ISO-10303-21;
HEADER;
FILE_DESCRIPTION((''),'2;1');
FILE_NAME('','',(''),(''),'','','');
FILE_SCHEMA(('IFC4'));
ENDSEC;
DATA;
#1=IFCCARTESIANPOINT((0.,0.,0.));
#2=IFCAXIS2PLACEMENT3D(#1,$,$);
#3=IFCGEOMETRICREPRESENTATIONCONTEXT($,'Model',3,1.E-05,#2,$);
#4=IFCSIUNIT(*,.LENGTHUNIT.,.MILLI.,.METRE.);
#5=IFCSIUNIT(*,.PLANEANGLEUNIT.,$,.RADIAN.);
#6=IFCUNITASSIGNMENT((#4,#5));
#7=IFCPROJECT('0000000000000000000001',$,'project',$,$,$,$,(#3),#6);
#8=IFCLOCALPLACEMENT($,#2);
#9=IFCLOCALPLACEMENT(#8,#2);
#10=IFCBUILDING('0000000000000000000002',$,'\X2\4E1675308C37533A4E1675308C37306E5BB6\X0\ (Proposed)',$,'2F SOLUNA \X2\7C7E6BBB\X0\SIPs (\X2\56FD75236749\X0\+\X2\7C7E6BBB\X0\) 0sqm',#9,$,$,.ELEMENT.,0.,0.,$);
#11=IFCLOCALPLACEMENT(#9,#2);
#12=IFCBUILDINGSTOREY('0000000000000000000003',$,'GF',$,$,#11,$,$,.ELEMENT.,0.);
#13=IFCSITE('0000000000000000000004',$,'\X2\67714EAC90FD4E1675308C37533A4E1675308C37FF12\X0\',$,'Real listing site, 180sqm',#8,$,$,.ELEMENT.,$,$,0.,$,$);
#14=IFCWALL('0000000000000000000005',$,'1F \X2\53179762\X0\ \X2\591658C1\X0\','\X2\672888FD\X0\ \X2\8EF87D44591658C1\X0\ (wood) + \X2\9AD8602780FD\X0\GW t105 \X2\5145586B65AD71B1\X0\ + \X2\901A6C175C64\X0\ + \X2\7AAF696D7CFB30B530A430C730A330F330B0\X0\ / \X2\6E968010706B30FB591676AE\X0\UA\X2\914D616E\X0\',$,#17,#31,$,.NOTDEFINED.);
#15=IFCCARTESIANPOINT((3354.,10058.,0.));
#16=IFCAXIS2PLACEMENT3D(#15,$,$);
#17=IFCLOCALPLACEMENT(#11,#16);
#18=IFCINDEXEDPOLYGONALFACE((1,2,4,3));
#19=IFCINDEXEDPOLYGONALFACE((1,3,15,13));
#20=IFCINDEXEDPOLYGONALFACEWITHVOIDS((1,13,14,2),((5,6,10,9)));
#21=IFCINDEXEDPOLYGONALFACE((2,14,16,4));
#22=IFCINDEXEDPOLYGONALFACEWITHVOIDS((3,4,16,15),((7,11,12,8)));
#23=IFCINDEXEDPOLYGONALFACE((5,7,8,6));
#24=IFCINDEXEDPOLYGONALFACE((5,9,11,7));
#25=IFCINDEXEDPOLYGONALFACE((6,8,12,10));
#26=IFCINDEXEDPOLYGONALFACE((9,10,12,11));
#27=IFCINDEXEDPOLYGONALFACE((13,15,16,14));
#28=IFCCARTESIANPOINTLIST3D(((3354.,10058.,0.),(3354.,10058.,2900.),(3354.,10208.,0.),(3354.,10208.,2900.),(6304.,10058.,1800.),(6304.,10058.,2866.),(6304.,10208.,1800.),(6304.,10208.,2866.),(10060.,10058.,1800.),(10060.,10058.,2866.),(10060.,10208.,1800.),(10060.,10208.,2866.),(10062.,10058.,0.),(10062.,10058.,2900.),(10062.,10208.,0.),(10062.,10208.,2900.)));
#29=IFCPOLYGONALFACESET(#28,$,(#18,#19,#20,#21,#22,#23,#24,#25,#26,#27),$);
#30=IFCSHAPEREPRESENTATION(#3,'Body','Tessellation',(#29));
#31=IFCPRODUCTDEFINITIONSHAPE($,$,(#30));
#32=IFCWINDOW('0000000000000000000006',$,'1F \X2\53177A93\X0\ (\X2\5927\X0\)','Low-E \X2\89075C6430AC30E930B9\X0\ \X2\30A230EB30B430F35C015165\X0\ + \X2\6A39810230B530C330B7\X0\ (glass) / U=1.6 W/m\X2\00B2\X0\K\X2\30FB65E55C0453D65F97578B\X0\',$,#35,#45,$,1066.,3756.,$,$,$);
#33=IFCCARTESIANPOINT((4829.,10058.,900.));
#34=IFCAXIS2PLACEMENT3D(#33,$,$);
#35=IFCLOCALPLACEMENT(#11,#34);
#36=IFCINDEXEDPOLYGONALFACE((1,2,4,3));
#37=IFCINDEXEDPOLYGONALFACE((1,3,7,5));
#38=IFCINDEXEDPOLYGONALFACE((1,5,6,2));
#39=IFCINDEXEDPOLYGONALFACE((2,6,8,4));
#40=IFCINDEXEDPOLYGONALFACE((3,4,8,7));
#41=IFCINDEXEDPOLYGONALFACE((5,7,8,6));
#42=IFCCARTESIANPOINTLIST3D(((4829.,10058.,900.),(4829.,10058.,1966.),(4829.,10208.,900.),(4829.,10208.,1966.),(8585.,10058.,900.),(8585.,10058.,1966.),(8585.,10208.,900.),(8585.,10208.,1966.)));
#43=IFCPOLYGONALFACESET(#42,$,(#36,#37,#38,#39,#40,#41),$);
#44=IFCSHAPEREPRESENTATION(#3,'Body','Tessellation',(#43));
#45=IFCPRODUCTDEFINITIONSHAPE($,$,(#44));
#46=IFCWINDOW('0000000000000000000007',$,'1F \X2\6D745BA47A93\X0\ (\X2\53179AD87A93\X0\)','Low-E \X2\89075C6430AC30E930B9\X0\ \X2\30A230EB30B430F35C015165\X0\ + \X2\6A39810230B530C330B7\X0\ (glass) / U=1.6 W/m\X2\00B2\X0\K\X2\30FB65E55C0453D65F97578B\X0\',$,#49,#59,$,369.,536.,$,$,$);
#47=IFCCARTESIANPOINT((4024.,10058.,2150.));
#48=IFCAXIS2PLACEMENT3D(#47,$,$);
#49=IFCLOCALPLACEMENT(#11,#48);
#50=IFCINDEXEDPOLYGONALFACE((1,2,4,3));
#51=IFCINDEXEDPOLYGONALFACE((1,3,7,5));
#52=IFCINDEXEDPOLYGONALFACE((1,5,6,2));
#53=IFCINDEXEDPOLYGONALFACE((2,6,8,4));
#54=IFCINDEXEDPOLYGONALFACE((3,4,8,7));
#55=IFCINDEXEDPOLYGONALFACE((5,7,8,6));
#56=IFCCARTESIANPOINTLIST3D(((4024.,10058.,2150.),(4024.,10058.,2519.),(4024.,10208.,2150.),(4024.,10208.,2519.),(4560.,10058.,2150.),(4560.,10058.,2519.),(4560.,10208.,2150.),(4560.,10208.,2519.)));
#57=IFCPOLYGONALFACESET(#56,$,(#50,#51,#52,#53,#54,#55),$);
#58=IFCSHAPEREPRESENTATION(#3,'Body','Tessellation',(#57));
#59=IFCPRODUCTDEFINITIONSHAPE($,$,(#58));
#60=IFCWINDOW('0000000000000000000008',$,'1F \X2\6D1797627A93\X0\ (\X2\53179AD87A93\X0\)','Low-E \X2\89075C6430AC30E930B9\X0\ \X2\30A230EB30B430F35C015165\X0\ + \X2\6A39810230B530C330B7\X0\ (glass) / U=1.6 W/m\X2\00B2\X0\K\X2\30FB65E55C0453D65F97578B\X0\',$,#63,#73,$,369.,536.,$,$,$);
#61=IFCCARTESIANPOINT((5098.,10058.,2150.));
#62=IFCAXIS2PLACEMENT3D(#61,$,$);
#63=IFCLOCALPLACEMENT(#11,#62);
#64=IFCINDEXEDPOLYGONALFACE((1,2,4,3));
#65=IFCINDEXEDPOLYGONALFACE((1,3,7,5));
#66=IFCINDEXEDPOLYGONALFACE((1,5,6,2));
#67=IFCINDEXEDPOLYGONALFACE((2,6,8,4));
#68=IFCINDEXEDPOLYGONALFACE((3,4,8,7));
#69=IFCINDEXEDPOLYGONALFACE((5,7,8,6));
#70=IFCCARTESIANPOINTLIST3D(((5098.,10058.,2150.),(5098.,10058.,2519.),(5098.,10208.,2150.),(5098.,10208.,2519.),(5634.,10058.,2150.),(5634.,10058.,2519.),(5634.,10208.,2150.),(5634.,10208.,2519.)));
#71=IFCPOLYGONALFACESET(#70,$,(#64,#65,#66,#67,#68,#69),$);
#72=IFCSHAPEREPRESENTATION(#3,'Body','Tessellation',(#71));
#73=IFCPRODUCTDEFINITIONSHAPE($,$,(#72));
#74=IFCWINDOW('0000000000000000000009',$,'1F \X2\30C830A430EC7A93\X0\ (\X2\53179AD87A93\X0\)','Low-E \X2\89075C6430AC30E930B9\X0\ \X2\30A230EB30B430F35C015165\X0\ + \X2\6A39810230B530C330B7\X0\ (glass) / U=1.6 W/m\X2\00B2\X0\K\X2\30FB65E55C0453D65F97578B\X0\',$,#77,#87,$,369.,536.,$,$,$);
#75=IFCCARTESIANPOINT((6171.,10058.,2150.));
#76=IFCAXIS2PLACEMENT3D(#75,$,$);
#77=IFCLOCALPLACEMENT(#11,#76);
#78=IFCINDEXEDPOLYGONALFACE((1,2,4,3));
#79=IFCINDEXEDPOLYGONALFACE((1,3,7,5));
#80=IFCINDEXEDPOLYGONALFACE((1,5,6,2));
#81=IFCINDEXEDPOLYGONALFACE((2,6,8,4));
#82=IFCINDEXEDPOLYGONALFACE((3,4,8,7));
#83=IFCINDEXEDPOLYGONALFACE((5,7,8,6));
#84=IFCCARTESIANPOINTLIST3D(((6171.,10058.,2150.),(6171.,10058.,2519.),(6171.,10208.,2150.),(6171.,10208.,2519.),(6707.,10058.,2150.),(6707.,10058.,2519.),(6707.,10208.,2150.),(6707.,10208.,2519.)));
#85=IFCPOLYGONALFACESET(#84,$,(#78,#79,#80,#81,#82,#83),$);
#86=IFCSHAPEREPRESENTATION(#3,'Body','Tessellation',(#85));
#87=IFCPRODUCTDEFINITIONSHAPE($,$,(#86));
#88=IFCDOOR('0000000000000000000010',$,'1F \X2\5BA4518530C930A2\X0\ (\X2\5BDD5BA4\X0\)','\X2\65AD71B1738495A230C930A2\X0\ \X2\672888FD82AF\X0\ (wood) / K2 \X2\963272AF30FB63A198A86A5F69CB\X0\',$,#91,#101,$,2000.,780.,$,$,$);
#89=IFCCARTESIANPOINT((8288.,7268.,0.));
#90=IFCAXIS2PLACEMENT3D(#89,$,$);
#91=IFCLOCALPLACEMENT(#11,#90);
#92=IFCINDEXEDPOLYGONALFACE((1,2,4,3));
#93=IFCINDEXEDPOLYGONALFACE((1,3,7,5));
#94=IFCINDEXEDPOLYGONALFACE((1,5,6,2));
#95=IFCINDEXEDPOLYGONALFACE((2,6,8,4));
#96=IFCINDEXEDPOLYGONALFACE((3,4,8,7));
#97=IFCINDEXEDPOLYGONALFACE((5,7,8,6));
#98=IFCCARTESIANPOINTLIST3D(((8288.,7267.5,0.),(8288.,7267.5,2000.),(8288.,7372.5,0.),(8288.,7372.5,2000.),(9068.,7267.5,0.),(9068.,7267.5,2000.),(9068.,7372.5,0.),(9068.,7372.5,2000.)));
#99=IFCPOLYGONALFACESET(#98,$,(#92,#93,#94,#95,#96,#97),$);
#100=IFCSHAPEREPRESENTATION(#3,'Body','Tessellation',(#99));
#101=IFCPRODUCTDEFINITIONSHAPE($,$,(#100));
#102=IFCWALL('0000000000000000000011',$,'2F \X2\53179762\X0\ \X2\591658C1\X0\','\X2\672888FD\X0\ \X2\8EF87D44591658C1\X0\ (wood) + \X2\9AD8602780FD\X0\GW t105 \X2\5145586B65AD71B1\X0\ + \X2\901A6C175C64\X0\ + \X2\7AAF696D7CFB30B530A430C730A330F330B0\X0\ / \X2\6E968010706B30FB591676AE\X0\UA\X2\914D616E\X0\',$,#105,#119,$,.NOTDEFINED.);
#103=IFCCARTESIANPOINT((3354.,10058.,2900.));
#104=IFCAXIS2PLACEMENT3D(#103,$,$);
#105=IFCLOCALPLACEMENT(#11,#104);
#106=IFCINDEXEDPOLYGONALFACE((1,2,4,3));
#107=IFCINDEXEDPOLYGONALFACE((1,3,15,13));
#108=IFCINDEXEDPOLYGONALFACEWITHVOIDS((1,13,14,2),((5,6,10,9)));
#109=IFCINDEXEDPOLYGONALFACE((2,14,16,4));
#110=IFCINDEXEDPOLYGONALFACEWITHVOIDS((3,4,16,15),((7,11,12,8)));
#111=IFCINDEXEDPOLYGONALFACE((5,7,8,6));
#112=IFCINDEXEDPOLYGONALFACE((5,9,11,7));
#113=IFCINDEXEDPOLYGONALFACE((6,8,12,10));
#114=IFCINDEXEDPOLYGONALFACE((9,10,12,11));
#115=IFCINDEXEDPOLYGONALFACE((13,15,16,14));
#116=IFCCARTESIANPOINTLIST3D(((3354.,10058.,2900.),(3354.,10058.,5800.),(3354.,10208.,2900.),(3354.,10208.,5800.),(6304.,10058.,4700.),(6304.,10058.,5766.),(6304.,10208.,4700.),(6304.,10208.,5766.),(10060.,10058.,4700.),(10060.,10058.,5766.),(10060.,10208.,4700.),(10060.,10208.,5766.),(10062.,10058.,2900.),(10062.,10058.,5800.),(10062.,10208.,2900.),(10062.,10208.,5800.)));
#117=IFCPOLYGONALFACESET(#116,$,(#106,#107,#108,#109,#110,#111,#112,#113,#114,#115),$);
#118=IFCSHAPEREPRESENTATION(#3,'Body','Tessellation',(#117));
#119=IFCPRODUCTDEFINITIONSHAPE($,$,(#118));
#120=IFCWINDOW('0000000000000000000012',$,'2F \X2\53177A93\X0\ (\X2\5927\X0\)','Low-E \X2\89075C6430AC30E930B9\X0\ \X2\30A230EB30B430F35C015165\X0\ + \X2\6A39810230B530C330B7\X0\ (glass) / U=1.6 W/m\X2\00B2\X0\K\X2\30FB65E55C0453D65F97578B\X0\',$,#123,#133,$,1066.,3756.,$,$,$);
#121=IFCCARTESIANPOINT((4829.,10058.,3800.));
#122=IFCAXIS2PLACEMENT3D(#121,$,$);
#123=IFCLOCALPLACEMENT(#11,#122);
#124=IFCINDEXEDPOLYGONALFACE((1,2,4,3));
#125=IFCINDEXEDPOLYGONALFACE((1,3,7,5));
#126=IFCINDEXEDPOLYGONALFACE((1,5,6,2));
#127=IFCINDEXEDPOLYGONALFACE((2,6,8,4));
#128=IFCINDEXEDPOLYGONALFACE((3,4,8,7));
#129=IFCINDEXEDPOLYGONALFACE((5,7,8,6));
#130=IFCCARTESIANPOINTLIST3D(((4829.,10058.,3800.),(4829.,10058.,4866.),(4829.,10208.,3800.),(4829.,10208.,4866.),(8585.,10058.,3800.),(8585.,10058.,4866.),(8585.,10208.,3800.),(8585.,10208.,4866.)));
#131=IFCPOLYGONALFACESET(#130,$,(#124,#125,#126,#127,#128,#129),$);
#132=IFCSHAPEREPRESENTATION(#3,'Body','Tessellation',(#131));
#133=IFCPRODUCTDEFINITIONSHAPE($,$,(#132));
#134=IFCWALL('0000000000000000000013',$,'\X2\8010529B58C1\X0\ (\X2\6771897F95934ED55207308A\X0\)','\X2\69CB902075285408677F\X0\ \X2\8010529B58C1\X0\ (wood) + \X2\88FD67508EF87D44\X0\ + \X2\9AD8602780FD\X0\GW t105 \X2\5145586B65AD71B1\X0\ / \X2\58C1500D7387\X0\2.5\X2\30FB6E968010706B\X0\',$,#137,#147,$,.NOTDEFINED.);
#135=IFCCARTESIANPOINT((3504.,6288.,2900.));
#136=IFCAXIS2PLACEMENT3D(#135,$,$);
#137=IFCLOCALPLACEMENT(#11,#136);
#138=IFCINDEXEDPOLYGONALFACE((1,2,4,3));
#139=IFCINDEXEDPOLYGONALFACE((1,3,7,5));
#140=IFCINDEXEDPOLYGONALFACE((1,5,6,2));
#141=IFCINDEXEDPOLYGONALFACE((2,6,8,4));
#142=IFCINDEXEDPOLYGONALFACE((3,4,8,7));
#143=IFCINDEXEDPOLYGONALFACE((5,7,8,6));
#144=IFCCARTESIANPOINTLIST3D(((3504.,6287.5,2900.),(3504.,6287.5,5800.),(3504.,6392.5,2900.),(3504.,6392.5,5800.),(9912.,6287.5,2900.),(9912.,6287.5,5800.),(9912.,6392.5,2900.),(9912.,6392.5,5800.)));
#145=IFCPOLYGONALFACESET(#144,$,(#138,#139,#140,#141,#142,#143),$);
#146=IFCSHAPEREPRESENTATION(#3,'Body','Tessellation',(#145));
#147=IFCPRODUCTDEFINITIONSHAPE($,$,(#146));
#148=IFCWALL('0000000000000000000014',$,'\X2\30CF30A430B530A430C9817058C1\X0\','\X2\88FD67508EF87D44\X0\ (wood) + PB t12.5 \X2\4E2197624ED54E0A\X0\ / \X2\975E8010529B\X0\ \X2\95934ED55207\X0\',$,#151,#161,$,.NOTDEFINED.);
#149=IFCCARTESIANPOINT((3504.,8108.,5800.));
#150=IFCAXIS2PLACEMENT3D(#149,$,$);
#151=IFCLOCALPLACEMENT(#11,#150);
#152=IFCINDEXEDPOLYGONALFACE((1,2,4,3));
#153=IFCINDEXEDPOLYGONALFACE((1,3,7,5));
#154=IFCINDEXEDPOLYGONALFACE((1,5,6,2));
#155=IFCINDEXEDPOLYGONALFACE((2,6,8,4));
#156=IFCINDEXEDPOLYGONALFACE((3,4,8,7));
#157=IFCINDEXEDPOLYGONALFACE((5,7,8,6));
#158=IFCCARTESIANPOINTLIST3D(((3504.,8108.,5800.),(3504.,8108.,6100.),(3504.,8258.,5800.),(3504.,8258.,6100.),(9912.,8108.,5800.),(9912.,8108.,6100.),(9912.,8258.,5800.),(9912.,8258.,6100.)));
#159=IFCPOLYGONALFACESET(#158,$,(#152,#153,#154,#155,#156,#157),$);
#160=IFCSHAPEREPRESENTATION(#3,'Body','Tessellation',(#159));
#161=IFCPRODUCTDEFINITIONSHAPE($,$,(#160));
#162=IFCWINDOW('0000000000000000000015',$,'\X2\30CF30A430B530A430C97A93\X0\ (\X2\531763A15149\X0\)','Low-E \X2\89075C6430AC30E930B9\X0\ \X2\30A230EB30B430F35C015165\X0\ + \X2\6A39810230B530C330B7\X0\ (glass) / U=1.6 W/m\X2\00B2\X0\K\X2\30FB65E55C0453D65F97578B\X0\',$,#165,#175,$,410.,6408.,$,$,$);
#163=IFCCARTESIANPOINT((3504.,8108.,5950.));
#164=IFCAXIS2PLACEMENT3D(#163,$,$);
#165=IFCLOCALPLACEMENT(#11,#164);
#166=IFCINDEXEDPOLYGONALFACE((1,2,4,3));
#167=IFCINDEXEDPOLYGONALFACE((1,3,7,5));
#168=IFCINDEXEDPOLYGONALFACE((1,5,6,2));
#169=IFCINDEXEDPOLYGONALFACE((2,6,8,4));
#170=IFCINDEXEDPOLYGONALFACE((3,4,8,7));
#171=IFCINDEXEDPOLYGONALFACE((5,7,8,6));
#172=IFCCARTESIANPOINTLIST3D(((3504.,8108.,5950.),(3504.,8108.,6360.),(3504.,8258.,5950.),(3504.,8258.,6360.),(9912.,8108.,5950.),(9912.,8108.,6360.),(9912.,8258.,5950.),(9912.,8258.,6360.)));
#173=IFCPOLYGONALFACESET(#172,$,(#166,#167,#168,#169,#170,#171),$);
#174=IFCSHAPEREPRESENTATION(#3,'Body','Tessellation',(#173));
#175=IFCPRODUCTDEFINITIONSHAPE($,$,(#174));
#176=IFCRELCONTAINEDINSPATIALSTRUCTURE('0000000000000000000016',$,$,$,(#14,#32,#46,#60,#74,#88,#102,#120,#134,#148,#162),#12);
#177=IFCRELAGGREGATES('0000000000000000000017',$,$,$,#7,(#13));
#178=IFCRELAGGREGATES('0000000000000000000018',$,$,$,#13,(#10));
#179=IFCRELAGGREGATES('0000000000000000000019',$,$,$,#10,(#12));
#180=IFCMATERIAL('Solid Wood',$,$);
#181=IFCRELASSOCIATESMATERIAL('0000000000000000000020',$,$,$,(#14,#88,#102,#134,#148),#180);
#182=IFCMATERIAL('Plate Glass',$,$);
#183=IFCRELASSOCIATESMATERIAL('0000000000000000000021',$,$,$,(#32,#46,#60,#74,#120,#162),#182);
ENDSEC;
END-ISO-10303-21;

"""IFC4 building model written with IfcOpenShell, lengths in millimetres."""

from ifc_helpers import new_model, si_unit, frame, frame_2d, origin, place, context, project, spatial, rectangle, extrude, material, element, fill, save


model = new_model("IFC4")

# Units and contexts
model_context = context("Model", 3, precision=1e-05, world=origin())
ifc_project = project(units=[si_unit("LENGTHUNIT", "METRE", prefix="MILLI"), si_unit("PLANEANGLEUNIT", "RADIAN")], contexts=[model_context])

# Site, building, storey
site_placement = place(None, origin())
site = spatial("IfcSite", under=ifc_project, at=site_placement, Name="東京都世田谷区世田谷２", ObjectType="Real listing site, 180sqm", CompositionType="ELEMENT", RefElevation=0.0)
building_placement = place(site_placement, origin())
building = spatial("IfcBuilding", under=site, at=building_placement, Name="世田谷区世田谷の家 (Proposed)", ObjectType="2F SOLUNA 籾殻SIPs (国産杉+籾殻) 0sqm", CompositionType="ELEMENT", ElevationOfRefHeight=0.0, ElevationOfTerrain=0.0)
storey_placement = place(building_placement, origin())
storey = spatial("IfcBuildingStorey", under=building, at=storey_placement, Name="GF", CompositionType="ELEMENT", Elevation=0.0)

# Wall, openings, windows
ifc_material_1 = material(Name="Solid Wood")
wall_1_placement = place(storey_placement, frame((3354.0, 10058.0, 0.0)))
wall_1 = element("IfcWall", 1, at=wall_1_placement, inside=storey, material=ifc_material_1, Name="1F 北面 外壁", Description="木製 軸組外壁 (wood) + 高性能GW t105 充填断熱 + 通気層 + 窯業系サイディング / 準耐火・外皮UA配慮", PredefinedType="NOTDEFINED", context=model_context, shape_type="SweptSolid", body=[
    extrude(rectangle(XDim=6708.0, YDim=150.0, at=frame_2d((3354.0, 75.0))), frame((3354.0, 10058.0, 0.0)), (0.0, 0.0, 1.0), 2900.0),
])
opening_1_placement = place(storey_placement, frame((4829.0, 10058.0, 900.0)))
opening_1 = element("IfcOpeningElement", 2, at=opening_1_placement, cuts=wall_1, PredefinedType="NOTDEFINED", context=model_context, shape_type="SweptSolid", body=[
    extrude(rectangle(XDim=3756.0, YDim=150.0, at=frame_2d((1878.0, 75.0))), frame((4829.0, 10058.0, 900.0)), (0.0, 0.0, 1.0), 1066.0),
])
opening_2_placement = place(storey_placement, frame((4024.0, 10058.0, 2150.0)))
opening_2 = element("IfcOpeningElement", 3, at=opening_2_placement, cuts=wall_1, PredefinedType="NOTDEFINED", context=model_context, shape_type="SweptSolid", body=[
    extrude(rectangle(XDim=536.0, YDim=150.0, at=frame_2d((268.0, 75.0))), frame((4024.0, 10058.0, 2150.0)), (0.0, 0.0, 1.0), 369.0),
])
opening_3_placement = place(storey_placement, frame((5098.0, 10058.0, 2150.0)))
opening_3 = element("IfcOpeningElement", 4, at=opening_3_placement, cuts=wall_1, PredefinedType="NOTDEFINED", context=model_context, shape_type="SweptSolid", body=[
    extrude(rectangle(XDim=536.0, YDim=150.0, at=frame_2d((268.0, 75.0))), frame((5098.0, 10058.0, 2150.0)), (0.0, 0.0, 1.0), 369.0),
])
opening_4_placement = place(storey_placement, frame((6171.0, 10058.0, 2150.0)))
opening_4 = element("IfcOpeningElement", 5, at=opening_4_placement, cuts=wall_1, PredefinedType="NOTDEFINED", context=model_context, shape_type="SweptSolid", body=[
    extrude(rectangle(XDim=536.0, YDim=150.0, at=frame_2d((268.0, 75.0))), frame((6171.0, 10058.0, 2150.0)), (0.0, 0.0, 1.0), 369.0),
])
ifc_material_2 = material(Name="Plate Glass")
window_1_placement = place(storey_placement, frame((4829.0, 10058.0, 900.0)))
window_1 = element("IfcWindow", 6, at=window_1_placement, inside=storey, material=ifc_material_2, Name="1F 北窓 (大)", Description="Low-E 複層ガラス アルゴン封入 + 樹脂サッシ (glass) / U=1.6 W/m²K・日射取得型", OverallHeight=1066.0, OverallWidth=3756.0, context=model_context, shape_type="SweptSolid", body=[
    extrude(rectangle(XDim=3756.0, YDim=150.0, at=frame_2d((1878.0, 75.0))), frame((4829.0, 10058.0, 900.0)), (0.0, 0.0, 1.0), 1066.0),
])
fill(opening_1, window_1)
window_2_placement = place(storey_placement, frame((4024.0, 10058.0, 2150.0)))
window_2 = element("IfcWindow", 7, at=window_2_placement, inside=storey, material=ifc_material_2, Name="1F 浴室窓 (北高窓)", Description="Low-E 複層ガラス アルゴン封入 + 樹脂サッシ (glass) / U=1.6 W/m²K・日射取得型", OverallHeight=369.0, OverallWidth=536.0, context=model_context, shape_type="SweptSolid", body=[
    extrude(rectangle(XDim=536.0, YDim=150.0, at=frame_2d((268.0, 75.0))), frame((4024.0, 10058.0, 2150.0)), (0.0, 0.0, 1.0), 369.0),
])
fill(opening_2, window_2)
window_3_placement = place(storey_placement, frame((5098.0, 10058.0, 2150.0)))
window_3 = element("IfcWindow", 8, at=window_3_placement, inside=storey, material=ifc_material_2, Name="1F 洗面窓 (北高窓)", Description="Low-E 複層ガラス アルゴン封入 + 樹脂サッシ (glass) / U=1.6 W/m²K・日射取得型", OverallHeight=369.0, OverallWidth=536.0, context=model_context, shape_type="SweptSolid", body=[
    extrude(rectangle(XDim=536.0, YDim=150.0, at=frame_2d((268.0, 75.0))), frame((5098.0, 10058.0, 2150.0)), (0.0, 0.0, 1.0), 369.0),
])
fill(opening_3, window_3)
window_4_placement = place(storey_placement, frame((6171.0, 10058.0, 2150.0)))
window_4 = element("IfcWindow", 9, at=window_4_placement, inside=storey, material=ifc_material_2, Name="1F トイレ窓 (北高窓)", Description="Low-E 複層ガラス アルゴン封入 + 樹脂サッシ (glass) / U=1.6 W/m²K・日射取得型", OverallHeight=369.0, OverallWidth=536.0, context=model_context, shape_type="SweptSolid", body=[
    extrude(rectangle(XDim=536.0, YDim=150.0, at=frame_2d((268.0, 75.0))), frame((6171.0, 10058.0, 2150.0)), (0.0, 0.0, 1.0), 369.0),
])
fill(opening_4, window_4)

# Door
door_1_placement = place(storey_placement, frame((8288.0, 7268.0, 0.0)))
element("IfcDoor", 10, at=door_1_placement, inside=storey, material=ifc_material_1, Name="1F 室内ドア (寝室)", Description="断熱玄関ドア 木製芯 (wood) / K2 防犯・採風機構", OverallHeight=2000.0, OverallWidth=780.0, context=model_context, shape_type="SweptSolid", body=[
    extrude(rectangle(XDim=780.0, YDim=105.0, at=frame_2d((390.0, 52.0))), frame((8288.0, 7268.0, 0.0)), (0.0, 0.0, 1.0), 2000.0),
])

# Wall, opening, window
wall_2_placement = place(storey_placement, frame((3354.0, 10058.0, 2900.0)))
wall_2 = element("IfcWall", 11, at=wall_2_placement, inside=storey, material=ifc_material_1, Name="2F 北面 外壁", Description="木製 軸組外壁 (wood) + 高性能GW t105 充填断熱 + 通気層 + 窯業系サイディング / 準耐火・外皮UA配慮", PredefinedType="NOTDEFINED", context=model_context, shape_type="SweptSolid", body=[
    extrude(rectangle(XDim=6708.0, YDim=150.0, at=frame_2d((3354.0, 75.0))), frame((3354.0, 10058.0, 2900.0)), (0.0, 0.0, 1.0), 2900.0),
])
opening_5_placement = place(storey_placement, frame((4829.0, 10058.0, 3800.0)))
opening_5 = element("IfcOpeningElement", 12, at=opening_5_placement, cuts=wall_2, PredefinedType="NOTDEFINED", context=model_context, shape_type="SweptSolid", body=[
    extrude(rectangle(XDim=3756.0, YDim=150.0, at=frame_2d((1878.0, 75.0))), frame((4829.0, 10058.0, 3800.0)), (0.0, 0.0, 1.0), 1066.0),
])
window_5_placement = place(storey_placement, frame((4829.0, 10058.0, 3800.0)))
window_5 = element("IfcWindow", 13, at=window_5_placement, inside=storey, material=ifc_material_2, Name="2F 北窓 (大)", Description="Low-E 複層ガラス アルゴン封入 + 樹脂サッシ (glass) / U=1.6 W/m²K・日射取得型", OverallHeight=1066.0, OverallWidth=3756.0, context=model_context, shape_type="SweptSolid", body=[
    extrude(rectangle(XDim=3756.0, YDim=150.0, at=frame_2d((1878.0, 75.0))), frame((4829.0, 10058.0, 3800.0)), (0.0, 0.0, 1.0), 1066.0),
])
fill(opening_5, window_5)

# Wall
wall_3_placement = place(storey_placement, frame((3504.0, 6288.0, 2900.0)))
element("IfcWall", 14, at=wall_3_placement, inside=storey, material=ifc_material_1, Name="耐力壁 (東西間仕切り)", Description="構造用合板 耐力壁 (wood) + 製材軸組 + 高性能GW t105 充填断熱 / 壁倍率2.5・準耐火", PredefinedType="NOTDEFINED", context=model_context, shape_type="SweptSolid", body=[
    extrude(rectangle(XDim=6408.0, YDim=105.0, at=frame_2d((3204.0, 52.0))), frame((3504.0, 6288.0, 2900.0)), (0.0, 0.0, 1.0), 2900.0),
])

# Wall, opening, window
wall_4_placement = place(storey_placement, frame((3504.0, 8108.0, 5800.0)))
wall_4 = element("IfcWall", 15, at=wall_4_placement, inside=storey, material=ifc_material_1, Name="ハイサイド腰壁", Description="製材軸組 (wood) + PB t12.5 両面仕上 / 非耐力 間仕切", PredefinedType="NOTDEFINED", context=model_context, shape_type="SweptSolid", body=[
    extrude(rectangle(XDim=6408.0, YDim=150.0, at=frame_2d((3204.0, 75.0))), frame((3504.0, 8108.0, 5800.0)), (0.0, 0.0, 1.0), 700.0),
])
opening_6_placement = place(storey_placement, frame((3504.0, 8108.0, 5950.0)))
opening_6 = element("IfcOpeningElement", 16, at=opening_6_placement, cuts=wall_4, PredefinedType="NOTDEFINED", context=model_context, shape_type="SweptSolid", body=[
    extrude(rectangle(XDim=6408.0, YDim=150.0, at=frame_2d((3204.0, 75.0))), frame((3504.0, 8108.0, 5950.0)), (0.0, 0.0, 1.0), 410.0),
])
window_6_placement = place(storey_placement, frame((3504.0, 8108.0, 5950.0)))
window_6 = element("IfcWindow", 17, at=window_6_placement, inside=storey, material=ifc_material_2, Name="ハイサイド窓 (北採光)", Description="Low-E 複層ガラス アルゴン封入 + 樹脂サッシ (glass) / U=1.6 W/m²K・日射取得型", OverallHeight=410.0, OverallWidth=6408.0, context=model_context, shape_type="SweptSolid", body=[
    extrude(rectangle(XDim=6408.0, YDim=150.0, at=frame_2d((3204.0, 75.0))), frame((3504.0, 8108.0, 5950.0)), (0.0, 0.0, 1.0), 410.0),
])
fill(opening_6, window_6)

save(model, "model.ifc")
